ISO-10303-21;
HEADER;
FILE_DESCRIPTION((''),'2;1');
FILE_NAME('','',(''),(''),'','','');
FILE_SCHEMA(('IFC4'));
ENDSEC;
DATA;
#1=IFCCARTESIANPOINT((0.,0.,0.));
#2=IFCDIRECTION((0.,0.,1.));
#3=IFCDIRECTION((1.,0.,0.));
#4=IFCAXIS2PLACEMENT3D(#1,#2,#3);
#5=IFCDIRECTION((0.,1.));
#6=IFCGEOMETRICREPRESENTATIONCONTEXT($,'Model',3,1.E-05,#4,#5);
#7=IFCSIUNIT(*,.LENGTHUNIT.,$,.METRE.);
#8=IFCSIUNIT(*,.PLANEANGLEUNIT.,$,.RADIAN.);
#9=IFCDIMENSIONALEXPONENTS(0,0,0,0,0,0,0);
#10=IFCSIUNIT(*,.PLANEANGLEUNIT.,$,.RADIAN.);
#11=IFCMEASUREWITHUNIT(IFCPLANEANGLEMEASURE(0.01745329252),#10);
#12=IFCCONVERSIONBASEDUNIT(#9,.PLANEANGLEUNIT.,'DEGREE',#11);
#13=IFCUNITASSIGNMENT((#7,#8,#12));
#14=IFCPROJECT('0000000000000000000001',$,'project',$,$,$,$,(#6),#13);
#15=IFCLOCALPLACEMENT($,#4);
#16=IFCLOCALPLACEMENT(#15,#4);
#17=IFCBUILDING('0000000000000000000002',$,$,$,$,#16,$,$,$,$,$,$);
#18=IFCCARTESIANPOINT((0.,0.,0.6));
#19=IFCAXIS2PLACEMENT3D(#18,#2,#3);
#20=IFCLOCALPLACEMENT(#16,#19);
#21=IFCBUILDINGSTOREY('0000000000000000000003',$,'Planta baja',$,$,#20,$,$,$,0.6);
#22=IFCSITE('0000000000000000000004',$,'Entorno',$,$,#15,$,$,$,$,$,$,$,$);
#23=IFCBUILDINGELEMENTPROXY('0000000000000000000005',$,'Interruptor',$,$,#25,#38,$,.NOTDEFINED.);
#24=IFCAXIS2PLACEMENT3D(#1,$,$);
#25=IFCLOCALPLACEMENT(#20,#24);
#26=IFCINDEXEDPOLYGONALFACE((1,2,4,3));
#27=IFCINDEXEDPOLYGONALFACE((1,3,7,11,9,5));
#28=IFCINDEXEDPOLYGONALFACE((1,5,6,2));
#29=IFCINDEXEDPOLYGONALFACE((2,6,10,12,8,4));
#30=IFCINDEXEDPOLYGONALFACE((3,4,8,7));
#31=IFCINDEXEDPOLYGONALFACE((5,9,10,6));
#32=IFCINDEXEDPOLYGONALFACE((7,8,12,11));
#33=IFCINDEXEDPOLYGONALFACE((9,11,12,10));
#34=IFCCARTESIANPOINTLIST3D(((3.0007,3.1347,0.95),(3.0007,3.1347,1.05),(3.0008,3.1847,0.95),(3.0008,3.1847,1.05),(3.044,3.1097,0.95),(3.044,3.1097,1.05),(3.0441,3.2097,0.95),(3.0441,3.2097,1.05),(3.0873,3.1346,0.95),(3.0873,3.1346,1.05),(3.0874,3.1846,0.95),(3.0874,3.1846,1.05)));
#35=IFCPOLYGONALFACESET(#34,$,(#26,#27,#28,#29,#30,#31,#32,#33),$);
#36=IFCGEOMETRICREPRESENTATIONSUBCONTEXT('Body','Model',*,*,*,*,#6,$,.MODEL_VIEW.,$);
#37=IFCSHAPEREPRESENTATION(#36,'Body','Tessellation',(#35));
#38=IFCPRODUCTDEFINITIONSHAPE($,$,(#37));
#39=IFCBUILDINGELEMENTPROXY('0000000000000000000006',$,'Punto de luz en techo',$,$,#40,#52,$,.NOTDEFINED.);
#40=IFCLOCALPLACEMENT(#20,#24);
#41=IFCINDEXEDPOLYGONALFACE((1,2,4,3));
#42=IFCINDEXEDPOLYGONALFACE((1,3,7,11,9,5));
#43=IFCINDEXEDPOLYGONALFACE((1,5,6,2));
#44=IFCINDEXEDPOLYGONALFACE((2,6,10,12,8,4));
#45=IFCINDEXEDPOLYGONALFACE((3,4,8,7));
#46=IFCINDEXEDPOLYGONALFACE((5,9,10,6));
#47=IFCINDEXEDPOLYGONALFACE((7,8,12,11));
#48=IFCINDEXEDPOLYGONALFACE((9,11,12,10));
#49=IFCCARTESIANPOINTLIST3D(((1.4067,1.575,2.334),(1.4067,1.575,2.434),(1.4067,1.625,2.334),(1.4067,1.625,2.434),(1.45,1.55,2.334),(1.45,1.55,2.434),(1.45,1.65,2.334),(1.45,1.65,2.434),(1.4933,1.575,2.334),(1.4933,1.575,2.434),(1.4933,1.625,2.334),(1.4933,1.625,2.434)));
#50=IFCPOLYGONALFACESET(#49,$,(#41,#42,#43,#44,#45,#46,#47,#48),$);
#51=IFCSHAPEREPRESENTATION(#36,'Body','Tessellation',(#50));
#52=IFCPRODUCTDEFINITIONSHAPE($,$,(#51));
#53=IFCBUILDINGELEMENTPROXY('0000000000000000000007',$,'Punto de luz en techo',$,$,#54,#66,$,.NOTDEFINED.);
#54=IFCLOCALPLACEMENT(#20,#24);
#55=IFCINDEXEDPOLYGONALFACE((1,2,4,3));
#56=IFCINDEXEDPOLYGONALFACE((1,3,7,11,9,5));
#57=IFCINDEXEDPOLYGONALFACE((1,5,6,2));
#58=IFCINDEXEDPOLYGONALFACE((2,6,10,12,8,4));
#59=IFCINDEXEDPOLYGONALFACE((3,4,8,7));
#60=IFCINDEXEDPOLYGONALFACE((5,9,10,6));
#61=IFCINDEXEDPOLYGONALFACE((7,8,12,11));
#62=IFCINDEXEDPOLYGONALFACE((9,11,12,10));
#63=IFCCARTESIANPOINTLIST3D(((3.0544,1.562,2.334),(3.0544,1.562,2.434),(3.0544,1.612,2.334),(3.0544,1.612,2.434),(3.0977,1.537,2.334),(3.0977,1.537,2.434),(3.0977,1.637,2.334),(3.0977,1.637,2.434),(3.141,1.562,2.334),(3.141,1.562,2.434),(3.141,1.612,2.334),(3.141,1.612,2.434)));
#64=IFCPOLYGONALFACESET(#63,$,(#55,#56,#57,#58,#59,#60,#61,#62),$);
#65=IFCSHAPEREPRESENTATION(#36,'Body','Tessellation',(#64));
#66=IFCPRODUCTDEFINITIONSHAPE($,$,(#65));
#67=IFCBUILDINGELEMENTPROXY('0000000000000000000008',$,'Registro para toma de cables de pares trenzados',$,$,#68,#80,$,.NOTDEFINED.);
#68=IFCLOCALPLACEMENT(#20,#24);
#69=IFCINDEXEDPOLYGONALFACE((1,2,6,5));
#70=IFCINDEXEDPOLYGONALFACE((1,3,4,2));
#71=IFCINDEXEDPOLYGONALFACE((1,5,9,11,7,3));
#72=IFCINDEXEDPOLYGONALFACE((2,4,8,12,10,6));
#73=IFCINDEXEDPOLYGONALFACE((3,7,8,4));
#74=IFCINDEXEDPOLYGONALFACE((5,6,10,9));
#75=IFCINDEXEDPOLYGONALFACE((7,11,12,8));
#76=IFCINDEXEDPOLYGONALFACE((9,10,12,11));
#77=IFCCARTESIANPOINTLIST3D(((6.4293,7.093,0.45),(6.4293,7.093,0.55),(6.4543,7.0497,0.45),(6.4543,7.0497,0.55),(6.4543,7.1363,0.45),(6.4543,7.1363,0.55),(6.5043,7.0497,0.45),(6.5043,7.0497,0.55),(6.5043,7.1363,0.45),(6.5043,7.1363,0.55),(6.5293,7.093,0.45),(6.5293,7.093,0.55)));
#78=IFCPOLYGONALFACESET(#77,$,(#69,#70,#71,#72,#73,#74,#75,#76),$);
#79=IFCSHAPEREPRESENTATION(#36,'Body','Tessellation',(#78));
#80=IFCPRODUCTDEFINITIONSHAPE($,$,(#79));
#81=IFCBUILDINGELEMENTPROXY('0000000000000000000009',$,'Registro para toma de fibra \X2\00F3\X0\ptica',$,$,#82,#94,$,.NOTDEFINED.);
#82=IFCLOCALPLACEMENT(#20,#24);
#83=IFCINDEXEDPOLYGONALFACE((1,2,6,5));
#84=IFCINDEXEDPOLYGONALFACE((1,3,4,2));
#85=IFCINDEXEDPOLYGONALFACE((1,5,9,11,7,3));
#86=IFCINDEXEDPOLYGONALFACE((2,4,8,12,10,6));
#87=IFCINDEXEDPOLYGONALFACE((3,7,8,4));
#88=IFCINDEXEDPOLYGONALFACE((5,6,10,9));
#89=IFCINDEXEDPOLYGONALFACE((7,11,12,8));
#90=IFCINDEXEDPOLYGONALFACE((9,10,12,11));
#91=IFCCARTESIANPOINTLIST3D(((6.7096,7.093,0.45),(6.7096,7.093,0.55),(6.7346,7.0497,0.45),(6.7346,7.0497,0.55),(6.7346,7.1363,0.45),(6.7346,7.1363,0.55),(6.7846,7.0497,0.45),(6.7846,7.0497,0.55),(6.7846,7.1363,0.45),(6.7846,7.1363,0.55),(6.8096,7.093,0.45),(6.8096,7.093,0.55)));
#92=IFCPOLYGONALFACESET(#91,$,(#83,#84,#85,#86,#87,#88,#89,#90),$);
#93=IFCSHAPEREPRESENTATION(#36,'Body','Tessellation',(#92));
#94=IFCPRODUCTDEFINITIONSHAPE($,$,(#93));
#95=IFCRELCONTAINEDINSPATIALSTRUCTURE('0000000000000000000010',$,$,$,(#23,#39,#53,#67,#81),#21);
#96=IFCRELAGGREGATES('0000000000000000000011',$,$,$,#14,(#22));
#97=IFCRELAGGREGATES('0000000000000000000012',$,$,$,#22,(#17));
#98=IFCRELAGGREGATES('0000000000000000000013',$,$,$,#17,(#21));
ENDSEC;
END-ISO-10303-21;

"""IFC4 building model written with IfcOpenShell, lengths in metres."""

from ifc_helpers import new_model, entity, si_unit, converted_unit, direction, frame, origin_with_axes, place, context, subcontext, project, spatial, polyline, outline, extrude, source, transform, mapped, element, save


model = new_model("IFC4")

# Units and contexts
model_context = context("Model", 3, precision=1e-05, world=origin_with_axes(), true_north=direction((0.0, 1.0)))
body_context = subcontext(model_context, "Body", "Model", "MODEL_VIEW")
ifc_project = project(units=[si_unit("LENGTHUNIT", "METRE"), si_unit("PLANEANGLEUNIT", "RADIAN"), converted_unit("PLANEANGLEUNIT", "DEGREE", entity("IfcPlaneAngleMeasure", 0.01745329252), si_unit("PLANEANGLEUNIT", "RADIAN"), dimensions=[0, 0, 0, 0, 0, 0, 0])], contexts=[model_context])

# Site, building, storey
site_placement = place(None, origin_with_axes())
site = spatial("IfcSite", under=ifc_project, at=site_placement, Name="Entorno")
building_placement = place(site_placement, origin_with_axes())
building = spatial("IfcBuilding", under=site, at=building_placement)
storey_placement = place(building_placement, frame((0.0, 0.0, 0.6), z_axis=(0.0, 0.0, 1.0), x_axis=(1.0, 0.0, 0.0)))
storey = spatial("IfcBuildingStorey", under=building, at=storey_placement, Name="Planta baja", Elevation=0.6)

# Building element proxies
shared_shape_1 = source(origin_with_axes(), body_context, "Body", "SolidModel", [
    extrude(outline(polyline([(0.05, 0.0), (0.025, 0.0433), (-0.025, 0.0433), (-0.05, 0.0), (-0.025, -0.0433), (0.025, -0.0433), (0.05, 0.0)])), frame((0.0, 0.0, -0.05), z_axis=(0.0, 0.0, 1.0), x_axis=(1.0, 0.0, 0.0)), (0.0, 0.0, 1.0), 0.1),
])
proxy_1_placement = place(storey_placement, frame((0.0, 0.0, -0.6), z_axis=(0.0, 0.0, 1.0), x_axis=(1.0, 0.0, 0.0)))
element("IfcBuildingElementProxy", 1, at=proxy_1_placement, inside=storey, Name="Interruptor", PredefinedType="NOTDEFINED", context=body_context, shape_type="Brep", body=[
    mapped(shared_shape_1, transform((3.0441, 3.1597, 1.6), x_axis=(-0.001016, -0.999999, 0.0), y_axis=(0.999999, -0.001016, 0.0), z_axis=(0.0, 0.0, 1.0))),
])
shared_shape_2 = source(origin_with_axes(), body_context, "Body", "SolidModel", [
    extrude(outline(polyline([(0.05, 0.0), (0.025, 0.0433), (-0.025, 0.0433), (-0.05, 0.0), (-0.025, -0.0433), (0.025, -0.0433), (0.05, 0.0)])), frame((0.0, 0.0, -0.05), z_axis=(0.0, 0.0, 1.0), x_axis=(1.0, 0.0, 0.0)), (0.0, 0.0, 1.0), 0.1),
])
proxy_2_placement = place(storey_placement, frame((0.0, 0.0, -0.6), z_axis=(0.0, 0.0, 1.0), x_axis=(1.0, 0.0, 0.0)))
element("IfcBuildingElementProxy", 2, at=proxy_2_placement, inside=storey, Name="Punto de luz en techo", PredefinedType="NOTDEFINED", context=body_context, shape_type="Brep", body=[
    mapped(shared_shape_2, transform((1.45, 1.6, 2.984), x_axis=(0.0, -1.0, 0.0), y_axis=(1.0, 0.0, 0.0), z_axis=(0.0, 0.0, 1.0))),
])
proxy_3_placement = place(storey_placement, frame((0.0, 0.0, -0.6), z_axis=(0.0, 0.0, 1.0), x_axis=(1.0, 0.0, 0.0)))
element("IfcBuildingElementProxy", 3, at=proxy_3_placement, inside=storey, Name="Punto de luz en techo", PredefinedType="NOTDEFINED", context=body_context, shape_type="Brep", body=[
    mapped(shared_shape_2, transform((3.0977, 1.587, 2.984), x_axis=(0.0, -1.0, 0.0), y_axis=(1.0, 0.0, 0.0), z_axis=(0.0, 0.0, 1.0))),
])
shared_shape_3 = source(origin_with_axes(), body_context, "Body", "SolidModel", [
    extrude(outline(polyline([(0.05, 0.0), (0.025, 0.0433), (-0.025, 0.0433), (-0.05, 0.0), (-0.025, -0.0433), (0.025, -0.0433), (0.05, 0.0)])), frame((0.0, 0.0, -0.05), z_axis=(0.0, 0.0, 1.0), x_axis=(1.0, 0.0, 0.0)), (0.0, 0.0, 1.0), 0.1),
])
proxy_4_placement = place(storey_placement, frame((0.0, 0.0, -0.6), z_axis=(0.0, 0.0, 1.0), x_axis=(1.0, 0.0, 0.0)))
element("IfcBuildingElementProxy", 4, at=proxy_4_placement, inside=storey, Name="Registro para toma de cables de pares trenzados", PredefinedType="NOTDEFINED", context=body_context, shape_type="Brep", body=[
    mapped(shared_shape_3, transform((6.4793, 7.093, 1.1), x_axis=(1.0, 0.0, 0.0), y_axis=(0.0, 1.0, 0.0), z_axis=(0.0, 0.0, 1.0))),
])
shared_shape_4 = source(origin_with_axes(), body_context, "Body", "SolidModel", [
    extrude(outline(polyline([(0.05, 0.0), (0.025, 0.0433), (-0.025, 0.0433), (-0.05, 0.0), (-0.025, -0.0433), (0.025, -0.0433), (0.05, 0.0)])), frame((0.0, 0.0, -0.05), z_axis=(0.0, 0.0, 1.0), x_axis=(1.0, 0.0, 0.0)), (0.0, 0.0, 1.0), 0.1),
])
proxy_5_placement = place(storey_placement, frame((0.0, 0.0, -0.6), z_axis=(0.0, 0.0, 1.0), x_axis=(1.0, 0.0, 0.0)))
element("IfcBuildingElementProxy", 5, at=proxy_5_placement, inside=storey, Name="Registro para toma de fibra óptica", PredefinedType="NOTDEFINED", context=body_context, shape_type="Brep", body=[
    mapped(shared_shape_4, transform((6.7596, 7.093, 1.1), x_axis=(1.0, 0.0, 0.0), y_axis=(0.0, 1.0, 0.0), z_axis=(0.0, 0.0, 1.0))),
])

save(model, "model.ifc")
